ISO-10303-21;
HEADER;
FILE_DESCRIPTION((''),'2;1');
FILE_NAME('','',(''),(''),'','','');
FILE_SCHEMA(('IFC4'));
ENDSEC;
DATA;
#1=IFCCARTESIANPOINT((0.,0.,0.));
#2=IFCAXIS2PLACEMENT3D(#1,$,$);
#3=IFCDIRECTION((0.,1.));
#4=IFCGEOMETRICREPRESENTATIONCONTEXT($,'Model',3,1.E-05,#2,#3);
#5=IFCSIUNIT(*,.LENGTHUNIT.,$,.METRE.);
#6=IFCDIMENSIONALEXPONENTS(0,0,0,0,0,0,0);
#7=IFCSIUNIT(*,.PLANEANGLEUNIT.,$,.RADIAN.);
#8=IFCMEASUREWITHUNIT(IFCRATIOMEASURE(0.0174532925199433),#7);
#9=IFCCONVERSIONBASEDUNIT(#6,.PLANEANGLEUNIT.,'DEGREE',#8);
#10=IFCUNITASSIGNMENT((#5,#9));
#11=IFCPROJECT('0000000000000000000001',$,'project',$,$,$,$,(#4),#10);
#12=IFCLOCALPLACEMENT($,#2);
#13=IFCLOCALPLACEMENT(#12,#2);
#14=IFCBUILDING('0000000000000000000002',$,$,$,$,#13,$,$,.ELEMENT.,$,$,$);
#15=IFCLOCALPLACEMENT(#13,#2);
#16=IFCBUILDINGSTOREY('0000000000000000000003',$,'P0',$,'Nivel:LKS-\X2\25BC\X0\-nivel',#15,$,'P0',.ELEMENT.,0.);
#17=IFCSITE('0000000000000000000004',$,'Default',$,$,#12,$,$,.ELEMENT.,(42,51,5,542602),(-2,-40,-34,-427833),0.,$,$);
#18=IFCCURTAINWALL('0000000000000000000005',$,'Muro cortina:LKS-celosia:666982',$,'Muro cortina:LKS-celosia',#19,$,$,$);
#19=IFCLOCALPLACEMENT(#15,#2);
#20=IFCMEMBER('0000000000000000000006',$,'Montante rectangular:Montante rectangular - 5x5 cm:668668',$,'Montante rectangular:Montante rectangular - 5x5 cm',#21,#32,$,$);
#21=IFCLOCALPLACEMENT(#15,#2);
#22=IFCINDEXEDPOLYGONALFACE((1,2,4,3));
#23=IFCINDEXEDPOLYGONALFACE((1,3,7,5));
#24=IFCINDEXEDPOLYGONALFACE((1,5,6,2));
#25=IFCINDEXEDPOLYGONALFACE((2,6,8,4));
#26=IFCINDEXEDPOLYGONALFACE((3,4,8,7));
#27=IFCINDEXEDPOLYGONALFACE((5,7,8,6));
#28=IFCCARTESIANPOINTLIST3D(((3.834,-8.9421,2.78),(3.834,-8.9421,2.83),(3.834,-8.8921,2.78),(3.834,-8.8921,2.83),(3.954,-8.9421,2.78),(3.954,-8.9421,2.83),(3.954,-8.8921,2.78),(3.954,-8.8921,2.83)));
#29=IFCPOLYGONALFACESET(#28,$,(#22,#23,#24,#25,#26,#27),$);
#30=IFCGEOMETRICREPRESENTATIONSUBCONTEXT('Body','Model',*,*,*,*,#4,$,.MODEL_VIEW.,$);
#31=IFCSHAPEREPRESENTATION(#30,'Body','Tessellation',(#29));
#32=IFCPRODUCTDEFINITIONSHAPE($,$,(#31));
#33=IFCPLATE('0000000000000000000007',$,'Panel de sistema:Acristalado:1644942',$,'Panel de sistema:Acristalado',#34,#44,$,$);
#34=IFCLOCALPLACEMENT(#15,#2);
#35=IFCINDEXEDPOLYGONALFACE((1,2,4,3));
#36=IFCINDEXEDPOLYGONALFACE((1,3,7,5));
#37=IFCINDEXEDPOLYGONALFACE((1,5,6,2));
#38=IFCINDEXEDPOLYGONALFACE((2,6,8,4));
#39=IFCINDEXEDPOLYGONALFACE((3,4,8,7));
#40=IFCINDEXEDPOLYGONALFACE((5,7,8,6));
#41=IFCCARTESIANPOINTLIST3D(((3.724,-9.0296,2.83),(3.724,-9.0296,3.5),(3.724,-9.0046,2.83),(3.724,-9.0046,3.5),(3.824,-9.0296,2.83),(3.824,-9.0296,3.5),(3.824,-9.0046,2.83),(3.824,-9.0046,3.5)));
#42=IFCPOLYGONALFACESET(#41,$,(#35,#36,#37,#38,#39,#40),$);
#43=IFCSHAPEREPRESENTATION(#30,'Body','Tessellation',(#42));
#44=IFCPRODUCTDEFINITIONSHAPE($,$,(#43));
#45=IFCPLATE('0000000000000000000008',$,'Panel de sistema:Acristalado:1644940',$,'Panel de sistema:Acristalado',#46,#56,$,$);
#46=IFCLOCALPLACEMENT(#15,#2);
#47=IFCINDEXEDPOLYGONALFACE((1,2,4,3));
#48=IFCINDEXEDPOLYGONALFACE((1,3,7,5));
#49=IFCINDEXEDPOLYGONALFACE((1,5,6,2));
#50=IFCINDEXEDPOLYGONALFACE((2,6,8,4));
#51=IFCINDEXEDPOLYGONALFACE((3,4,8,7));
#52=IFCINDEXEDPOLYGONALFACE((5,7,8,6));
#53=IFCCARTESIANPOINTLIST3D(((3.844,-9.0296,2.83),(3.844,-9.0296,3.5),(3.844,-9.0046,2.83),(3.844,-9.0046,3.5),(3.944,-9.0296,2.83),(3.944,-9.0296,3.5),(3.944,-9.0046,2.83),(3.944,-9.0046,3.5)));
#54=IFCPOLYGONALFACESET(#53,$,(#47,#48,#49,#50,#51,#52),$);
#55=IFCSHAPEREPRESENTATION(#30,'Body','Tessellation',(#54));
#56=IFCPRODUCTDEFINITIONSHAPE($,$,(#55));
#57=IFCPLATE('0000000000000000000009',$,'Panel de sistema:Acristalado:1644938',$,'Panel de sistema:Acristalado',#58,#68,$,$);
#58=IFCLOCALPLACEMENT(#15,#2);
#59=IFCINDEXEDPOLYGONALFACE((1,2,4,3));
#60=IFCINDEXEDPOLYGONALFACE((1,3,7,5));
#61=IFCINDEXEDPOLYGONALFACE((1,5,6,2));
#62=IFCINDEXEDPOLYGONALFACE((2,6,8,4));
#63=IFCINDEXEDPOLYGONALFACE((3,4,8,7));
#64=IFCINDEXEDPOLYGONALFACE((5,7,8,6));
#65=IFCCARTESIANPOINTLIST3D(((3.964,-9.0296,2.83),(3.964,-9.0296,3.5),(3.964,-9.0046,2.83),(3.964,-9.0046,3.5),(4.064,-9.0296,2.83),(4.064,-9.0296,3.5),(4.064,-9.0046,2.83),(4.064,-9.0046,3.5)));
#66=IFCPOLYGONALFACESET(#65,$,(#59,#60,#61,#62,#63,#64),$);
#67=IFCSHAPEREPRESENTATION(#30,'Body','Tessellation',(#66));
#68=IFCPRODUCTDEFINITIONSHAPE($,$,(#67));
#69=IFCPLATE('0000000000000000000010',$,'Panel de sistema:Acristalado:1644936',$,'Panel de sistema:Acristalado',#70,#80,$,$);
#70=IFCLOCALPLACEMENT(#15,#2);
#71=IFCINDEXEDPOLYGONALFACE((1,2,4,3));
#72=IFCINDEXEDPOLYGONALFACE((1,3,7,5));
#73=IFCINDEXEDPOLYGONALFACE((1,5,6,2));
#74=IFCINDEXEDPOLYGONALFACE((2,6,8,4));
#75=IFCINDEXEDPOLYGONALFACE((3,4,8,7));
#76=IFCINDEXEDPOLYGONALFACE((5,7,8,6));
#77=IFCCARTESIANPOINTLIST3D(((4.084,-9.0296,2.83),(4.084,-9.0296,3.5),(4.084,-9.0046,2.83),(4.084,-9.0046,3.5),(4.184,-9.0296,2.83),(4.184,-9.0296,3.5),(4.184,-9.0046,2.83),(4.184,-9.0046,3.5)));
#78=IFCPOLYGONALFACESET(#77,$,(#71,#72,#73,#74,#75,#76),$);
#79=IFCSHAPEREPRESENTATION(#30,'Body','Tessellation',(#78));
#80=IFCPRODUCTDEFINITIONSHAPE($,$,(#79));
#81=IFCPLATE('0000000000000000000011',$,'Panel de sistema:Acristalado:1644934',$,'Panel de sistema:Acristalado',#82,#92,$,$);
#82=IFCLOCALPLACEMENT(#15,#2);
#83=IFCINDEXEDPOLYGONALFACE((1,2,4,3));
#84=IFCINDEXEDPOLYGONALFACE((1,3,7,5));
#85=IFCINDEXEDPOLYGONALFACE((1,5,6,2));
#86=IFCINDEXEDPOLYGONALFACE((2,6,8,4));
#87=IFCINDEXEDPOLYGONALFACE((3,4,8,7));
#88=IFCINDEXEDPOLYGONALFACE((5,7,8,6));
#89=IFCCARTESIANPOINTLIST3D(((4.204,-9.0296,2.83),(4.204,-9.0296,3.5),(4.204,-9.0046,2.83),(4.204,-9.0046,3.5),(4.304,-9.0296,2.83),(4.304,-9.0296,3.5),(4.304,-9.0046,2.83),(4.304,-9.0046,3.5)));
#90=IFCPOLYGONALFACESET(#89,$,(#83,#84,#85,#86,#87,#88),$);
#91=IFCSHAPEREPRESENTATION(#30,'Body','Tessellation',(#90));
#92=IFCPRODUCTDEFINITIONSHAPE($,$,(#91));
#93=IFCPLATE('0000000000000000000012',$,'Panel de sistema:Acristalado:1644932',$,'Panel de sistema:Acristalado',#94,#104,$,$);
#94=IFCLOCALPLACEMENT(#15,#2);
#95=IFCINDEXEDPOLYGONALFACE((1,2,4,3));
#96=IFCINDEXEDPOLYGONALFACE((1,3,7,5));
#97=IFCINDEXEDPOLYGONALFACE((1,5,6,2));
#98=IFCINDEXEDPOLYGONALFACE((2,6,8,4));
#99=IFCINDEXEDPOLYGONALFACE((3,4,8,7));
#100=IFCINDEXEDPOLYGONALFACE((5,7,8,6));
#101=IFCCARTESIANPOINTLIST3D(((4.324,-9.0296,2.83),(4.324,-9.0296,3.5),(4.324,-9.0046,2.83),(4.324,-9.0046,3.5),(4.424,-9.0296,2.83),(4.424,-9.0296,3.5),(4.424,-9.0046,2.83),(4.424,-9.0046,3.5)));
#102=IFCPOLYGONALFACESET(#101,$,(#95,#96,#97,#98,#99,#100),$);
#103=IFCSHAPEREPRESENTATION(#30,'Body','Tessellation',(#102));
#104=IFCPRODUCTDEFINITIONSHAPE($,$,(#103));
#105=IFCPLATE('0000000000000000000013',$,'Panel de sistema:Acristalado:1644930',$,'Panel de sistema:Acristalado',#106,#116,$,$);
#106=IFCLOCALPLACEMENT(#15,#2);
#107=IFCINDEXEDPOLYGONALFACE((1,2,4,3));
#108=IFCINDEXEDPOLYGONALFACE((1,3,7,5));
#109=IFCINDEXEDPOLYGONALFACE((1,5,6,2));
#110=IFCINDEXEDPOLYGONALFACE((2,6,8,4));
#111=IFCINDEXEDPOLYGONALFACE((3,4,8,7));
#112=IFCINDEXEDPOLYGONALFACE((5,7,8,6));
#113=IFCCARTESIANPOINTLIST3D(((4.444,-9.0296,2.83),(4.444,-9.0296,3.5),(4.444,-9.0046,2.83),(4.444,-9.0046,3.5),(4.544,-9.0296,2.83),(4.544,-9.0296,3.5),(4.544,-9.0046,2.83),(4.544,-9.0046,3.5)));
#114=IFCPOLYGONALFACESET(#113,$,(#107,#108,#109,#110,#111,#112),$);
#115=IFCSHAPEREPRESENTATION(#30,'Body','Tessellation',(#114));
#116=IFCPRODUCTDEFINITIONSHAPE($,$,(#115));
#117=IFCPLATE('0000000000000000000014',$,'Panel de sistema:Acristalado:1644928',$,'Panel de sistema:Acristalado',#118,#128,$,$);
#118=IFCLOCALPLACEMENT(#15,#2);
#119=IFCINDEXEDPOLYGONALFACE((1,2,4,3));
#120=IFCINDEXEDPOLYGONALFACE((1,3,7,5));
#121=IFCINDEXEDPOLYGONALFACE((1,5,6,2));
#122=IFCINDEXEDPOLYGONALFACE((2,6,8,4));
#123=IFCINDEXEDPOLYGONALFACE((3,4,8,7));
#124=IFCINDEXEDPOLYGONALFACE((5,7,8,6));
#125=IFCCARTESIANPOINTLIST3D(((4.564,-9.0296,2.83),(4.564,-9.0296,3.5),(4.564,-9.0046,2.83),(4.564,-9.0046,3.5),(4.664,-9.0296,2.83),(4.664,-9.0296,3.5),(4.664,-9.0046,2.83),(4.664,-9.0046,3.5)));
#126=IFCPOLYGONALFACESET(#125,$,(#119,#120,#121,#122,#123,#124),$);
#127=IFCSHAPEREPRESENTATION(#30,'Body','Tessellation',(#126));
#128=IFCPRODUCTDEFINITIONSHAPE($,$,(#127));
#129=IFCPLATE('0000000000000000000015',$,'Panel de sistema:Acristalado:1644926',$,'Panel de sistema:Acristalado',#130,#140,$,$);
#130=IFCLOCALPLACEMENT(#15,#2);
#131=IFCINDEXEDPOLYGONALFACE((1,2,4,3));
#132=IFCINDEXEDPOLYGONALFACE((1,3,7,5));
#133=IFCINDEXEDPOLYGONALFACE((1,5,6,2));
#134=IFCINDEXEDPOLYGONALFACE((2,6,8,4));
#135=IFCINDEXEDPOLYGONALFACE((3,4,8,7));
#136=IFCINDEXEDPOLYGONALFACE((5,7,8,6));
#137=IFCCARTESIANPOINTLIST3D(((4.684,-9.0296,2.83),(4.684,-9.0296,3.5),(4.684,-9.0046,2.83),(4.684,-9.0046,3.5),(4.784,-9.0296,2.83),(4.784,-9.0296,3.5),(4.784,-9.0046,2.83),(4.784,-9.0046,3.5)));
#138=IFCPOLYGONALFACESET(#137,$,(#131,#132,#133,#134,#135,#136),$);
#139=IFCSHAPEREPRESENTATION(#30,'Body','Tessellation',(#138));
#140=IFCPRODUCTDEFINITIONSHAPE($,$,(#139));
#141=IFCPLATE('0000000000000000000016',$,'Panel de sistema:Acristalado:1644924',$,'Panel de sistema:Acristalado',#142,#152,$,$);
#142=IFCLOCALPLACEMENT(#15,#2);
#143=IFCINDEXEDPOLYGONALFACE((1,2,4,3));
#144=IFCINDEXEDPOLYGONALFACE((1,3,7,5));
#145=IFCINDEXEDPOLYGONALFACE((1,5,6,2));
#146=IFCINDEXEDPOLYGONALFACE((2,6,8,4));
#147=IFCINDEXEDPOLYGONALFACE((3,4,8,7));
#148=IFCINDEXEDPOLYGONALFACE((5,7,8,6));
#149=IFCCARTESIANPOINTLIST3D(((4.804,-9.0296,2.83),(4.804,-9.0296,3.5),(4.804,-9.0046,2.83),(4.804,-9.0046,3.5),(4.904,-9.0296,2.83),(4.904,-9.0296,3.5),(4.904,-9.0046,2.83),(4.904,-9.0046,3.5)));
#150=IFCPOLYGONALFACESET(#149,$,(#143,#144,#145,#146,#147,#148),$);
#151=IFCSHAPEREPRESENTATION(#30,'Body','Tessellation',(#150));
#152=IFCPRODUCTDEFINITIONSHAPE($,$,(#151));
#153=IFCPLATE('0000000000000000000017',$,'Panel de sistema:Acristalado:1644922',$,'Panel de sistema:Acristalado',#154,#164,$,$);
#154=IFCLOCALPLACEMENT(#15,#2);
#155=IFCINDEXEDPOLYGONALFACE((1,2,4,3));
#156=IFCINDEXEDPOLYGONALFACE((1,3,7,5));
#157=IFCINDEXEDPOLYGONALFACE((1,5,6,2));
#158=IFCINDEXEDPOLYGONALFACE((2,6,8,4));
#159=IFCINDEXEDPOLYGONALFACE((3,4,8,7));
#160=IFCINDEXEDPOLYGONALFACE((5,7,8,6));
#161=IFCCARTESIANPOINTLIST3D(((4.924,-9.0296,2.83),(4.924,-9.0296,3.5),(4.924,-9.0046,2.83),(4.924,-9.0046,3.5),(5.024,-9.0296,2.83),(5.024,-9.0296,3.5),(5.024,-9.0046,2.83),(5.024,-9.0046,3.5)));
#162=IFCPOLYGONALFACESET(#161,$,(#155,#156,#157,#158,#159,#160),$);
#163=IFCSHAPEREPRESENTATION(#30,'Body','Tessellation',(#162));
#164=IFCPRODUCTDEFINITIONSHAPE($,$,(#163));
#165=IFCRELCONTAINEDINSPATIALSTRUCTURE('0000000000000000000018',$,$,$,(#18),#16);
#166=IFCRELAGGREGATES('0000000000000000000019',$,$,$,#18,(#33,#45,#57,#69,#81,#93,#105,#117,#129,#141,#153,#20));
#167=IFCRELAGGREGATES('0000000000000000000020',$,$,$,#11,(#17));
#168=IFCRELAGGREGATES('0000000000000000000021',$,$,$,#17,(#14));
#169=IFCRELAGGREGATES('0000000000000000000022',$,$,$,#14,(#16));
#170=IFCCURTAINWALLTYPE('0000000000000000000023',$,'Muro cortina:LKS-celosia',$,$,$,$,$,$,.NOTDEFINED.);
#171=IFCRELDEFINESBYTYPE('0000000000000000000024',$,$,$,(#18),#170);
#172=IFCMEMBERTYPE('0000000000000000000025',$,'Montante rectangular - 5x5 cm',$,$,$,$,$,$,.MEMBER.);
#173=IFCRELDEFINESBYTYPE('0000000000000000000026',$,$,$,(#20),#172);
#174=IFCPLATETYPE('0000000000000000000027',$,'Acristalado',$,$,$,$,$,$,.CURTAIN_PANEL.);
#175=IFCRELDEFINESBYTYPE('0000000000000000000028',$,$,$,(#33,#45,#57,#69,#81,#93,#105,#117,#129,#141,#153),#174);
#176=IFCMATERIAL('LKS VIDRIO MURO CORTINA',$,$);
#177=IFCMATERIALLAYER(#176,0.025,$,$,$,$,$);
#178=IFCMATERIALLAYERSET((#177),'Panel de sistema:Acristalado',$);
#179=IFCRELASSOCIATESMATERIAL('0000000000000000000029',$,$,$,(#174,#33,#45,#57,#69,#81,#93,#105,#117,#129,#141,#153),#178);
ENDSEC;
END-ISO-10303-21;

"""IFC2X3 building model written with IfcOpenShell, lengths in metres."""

from ifc_helpers import new_model, entity, si_unit, converted_unit, direction, frame, origin, origin_2d_with_axis, place, context, subcontext, project, spatial, rectangle, extrude, source, transform, mapped, material, layer, layer_set, layer_usage, type_object, type_shapes, element, aggregate, save


model = new_model("IFC2X3")

# Units and contexts
model_context = context("Model", 3, precision=1e-05, world=origin(), true_north=direction((0.0, 1.0)))
body_context = subcontext(model_context, "Body", "Model", "MODEL_VIEW")
ifc_project = project(units=[si_unit("LENGTHUNIT", "METRE"), converted_unit("PLANEANGLEUNIT", "DEGREE", entity("IfcRatioMeasure", 0.0174532925199433), si_unit("PLANEANGLEUNIT", "RADIAN"), dimensions=[0, 0, 0, 0, 0, 0, 0])], contexts=[model_context])

# Site, building, storey
site_placement = place(None, origin())
site = spatial("IfcSite", under=ifc_project, at=site_placement, Name="Default", CompositionType="ELEMENT", RefLatitude=(42, 51, 5, 542602), RefLongitude=(-2, -40, -34, -427833), RefElevation=0.0)
building_placement = place(site_placement, origin())
building = spatial("IfcBuilding", under=site, at=building_placement, CompositionType="ELEMENT")
storey_placement = place(building_placement, origin())
storey = spatial("IfcBuildingStorey", under=building, at=storey_placement, Name="P0", ObjectType="Nivel:LKS-▼-nivel", LongName="P0", CompositionType="ELEMENT", Elevation=0.0)

# Curtain wall, member, plates
curtain_wall_type = type_object("IfcCurtainWallType", Name="Muro cortina:LKS-celosia", PredefinedType="NOTDEFINED")
curtain_wall_placement = place(storey_placement, origin())
curtain_wall = element("IfcCurtainWall", 1, at=curtain_wall_placement, inside=storey, type_object=curtain_wall_type, Name="Muro cortina:LKS-celosia:666982", ObjectType="Muro cortina:LKS-celosia")
member_type_1 = type_object("IfcMemberType", Name="Montante rectangular - 5x5 cm", PredefinedType="MEMBER")
shared_shape_1 = source(origin(), body_context, "Body", "SweptSolid", [
    extrude(rectangle(XDim=0.05, YDim=0.05, at=origin_2d_with_axis()), frame((-0.025, -0.1, -0.12), z_axis=(0.0, 0.0, 1.0), x_axis=(0.0, -1.0, 0.0)), (0.0, 0.0, 1.0), 0.12),
])
type_shapes(member_type_1, [shared_shape_1])
member_1_placement = place(storey_placement, frame((3.834, -9.0171, 2.78), z_axis=(-1.0, 0.0, 0.0), x_axis=(0.0, 0.0, -1.0)))
member_1 = element("IfcMember", 2, at=member_1_placement, type_object=member_type_1, Name="Montante rectangular:Montante rectangular - 5x5 cm:668668", ObjectType="Montante rectangular:Montante rectangular - 5x5 cm", context=body_context, shape_type="MappedRepresentation", body=[
    mapped(shared_shape_1, transform((0.0, 0.0, 0.0), scale=1.0)),
])
ifc_material = material(Name="LKS VIDRIO MURO CORTINA")
ifc_layer = layer(ifc_material, 0.025)
ifc_layer_set = layer_set([ifc_layer], Name="Panel de sistema:Acristalado")
ifc_layer_usage_1 = layer_usage(ifc_layer_set, "AXIS3", "POSITIVE", 0.0)
plate_type = type_object("IfcPlateType", Name="Acristalado", PredefinedType="CURTAIN_PANEL", material=ifc_layer_set)
shared_shape_2 = source(origin(), body_context, "Body", "SweptSolid", [
    extrude(rectangle(XDim=0.025, YDim=0.1, at=origin_2d_with_axis()), frame((0.0, 0.0, 0.0), z_axis=(0.0, 0.0, 1.0), x_axis=(0.0, 1.0, 0.0)), (0.0, 0.0, 1.0), 0.67),
])
type_shapes(plate_type, [shared_shape_2])
plate_1_placement = place(curtain_wall_placement, frame((3.774, -9.0171, 2.83)))
plate_1 = element("IfcPlate", 3, at=plate_1_placement, type_object=plate_type, material=ifc_layer_usage_1, Name="Panel de sistema:Acristalado:1644942", ObjectType="Panel de sistema:Acristalado", context=body_context, shape_type="MappedRepresentation", body=[
    mapped(shared_shape_2, transform((0.0, 0.0, 0.0), scale=1.0)),
])
ifc_layer_usage_2 = layer_usage(ifc_layer_set, "AXIS3", "POSITIVE", 0.0)
plate_2_placement = place(curtain_wall_placement, frame((3.894, -9.0171, 2.83)))
plate_2 = element("IfcPlate", 4, at=plate_2_placement, type_object=plate_type, material=ifc_layer_usage_2, Name="Panel de sistema:Acristalado:1644940", ObjectType="Panel de sistema:Acristalado", context=body_context, shape_type="MappedRepresentation", body=[
    mapped(shared_shape_2, transform((0.0, 0.0, 0.0), scale=1.0)),
])
ifc_layer_usage_3 = layer_usage(ifc_layer_set, "AXIS3", "POSITIVE", 0.0)
plate_3_placement = place(curtain_wall_placement, frame((4.014, -9.0171, 2.83)))
plate_3 = element("IfcPlate", 5, at=plate_3_placement, type_object=plate_type, material=ifc_layer_usage_3, Name="Panel de sistema:Acristalado:1644938", ObjectType="Panel de sistema:Acristalado", context=body_context, shape_type="MappedRepresentation", body=[
    mapped(shared_shape_2, transform((0.0, 0.0, 0.0), scale=1.0)),
])
ifc_layer_usage_4 = layer_usage(ifc_layer_set, "AXIS3", "POSITIVE", 0.0)
plate_4_placement = place(curtain_wall_placement, frame((4.134, -9.0171, 2.83)))
plate_4 = element("IfcPlate", 6, at=plate_4_placement, type_object=plate_type, material=ifc_layer_usage_4, Name="Panel de sistema:Acristalado:1644936", ObjectType="Panel de sistema:Acristalado", context=body_context, shape_type="MappedRepresentation", body=[
    mapped(shared_shape_2, transform((0.0, 0.0, 0.0), scale=1.0)),
])
ifc_layer_usage_5 = layer_usage(ifc_layer_set, "AXIS3", "POSITIVE", 0.0)
plate_5_placement = place(curtain_wall_placement, frame((4.254, -9.0171, 2.83)))
plate_5 = element("IfcPlate", 7, at=plate_5_placement, type_object=plate_type, material=ifc_layer_usage_5, Name="Panel de sistema:Acristalado:1644934", ObjectType="Panel de sistema:Acristalado", context=body_context, shape_type="MappedRepresentation", body=[
    mapped(shared_shape_2, transform((0.0, 0.0, 0.0), scale=1.0)),
])
ifc_layer_usage_6 = layer_usage(ifc_layer_set, "AXIS3", "POSITIVE", 0.0)
plate_6_placement = place(curtain_wall_placement, frame((4.374, -9.0171, 2.83)))
plate_6 = element("IfcPlate", 8, at=plate_6_placement, type_object=plate_type, material=ifc_layer_usage_6, Name="Panel de sistema:Acristalado:1644932", ObjectType="Panel de sistema:Acristalado", context=body_context, shape_type="MappedRepresentation", body=[
    mapped(shared_shape_2, transform((0.0, 0.0, 0.0), scale=1.0)),
])
ifc_layer_usage_7 = layer_usage(ifc_layer_set, "AXIS3", "POSITIVE", 0.0)
plate_7_placement = place(curtain_wall_placement, frame((4.494, -9.0171, 2.83)))
plate_7 = element("IfcPlate", 9, at=plate_7_placement, type_object=plate_type, material=ifc_layer_usage_7, Name="Panel de sistema:Acristalado:1644930", ObjectType="Panel de sistema:Acristalado", context=body_context, shape_type="MappedRepresentation", body=[
    mapped(shared_shape_2, transform((0.0, 0.0, 0.0), scale=1.0)),
])
ifc_layer_usage_8 = layer_usage(ifc_layer_set, "AXIS3", "POSITIVE", 0.0)
plate_8_placement = place(curtain_wall_placement, frame((4.614, -9.0171, 2.83)))
plate_8 = element("IfcPlate", 10, at=plate_8_placement, type_object=plate_type, material=ifc_layer_usage_8, Name="Panel de sistema:Acristalado:1644928", ObjectType="Panel de sistema:Acristalado", context=body_context, shape_type="MappedRepresentation", body=[
    mapped(shared_shape_2, transform((0.0, 0.0, 0.0), scale=1.0)),
])
ifc_layer_usage_9 = layer_usage(ifc_layer_set, "AXIS3", "POSITIVE", 0.0)
plate_9_placement = place(curtain_wall_placement, frame((4.734, -9.0171, 2.83)))
plate_9 = element("IfcPlate", 11, at=plate_9_placement, type_object=plate_type, material=ifc_layer_usage_9, Name="Panel de sistema:Acristalado:1644926", ObjectType="Panel de sistema:Acristalado", context=body_context, shape_type="MappedRepresentation", body=[
    mapped(shared_shape_2, transform((0.0, 0.0, 0.0), scale=1.0)),
])
ifc_layer_usage_10 = layer_usage(ifc_layer_set, "AXIS3", "POSITIVE", 0.0)
plate_10_placement = place(curtain_wall_placement, frame((4.854, -9.0171, 2.83)))
plate_10 = element("IfcPlate", 12, at=plate_10_placement, type_object=plate_type, material=ifc_layer_usage_10, Name="Panel de sistema:Acristalado:1644924", ObjectType="Panel de sistema:Acristalado", context=body_context, shape_type="MappedRepresentation", body=[
    mapped(shared_shape_2, transform((0.0, 0.0, 0.0), scale=1.0)),
])
ifc_layer_usage_11 = layer_usage(ifc_layer_set, "AXIS3", "POSITIVE", 0.0)
plate_11_placement = place(curtain_wall_placement, frame((4.974, -9.0171, 2.83)))
plate_11 = element("IfcPlate", 13, at=plate_11_placement, type_object=plate_type, material=ifc_layer_usage_11, Name="Panel de sistema:Acristalado:1644922", ObjectType="Panel de sistema:Acristalado", context=body_context, shape_type="MappedRepresentation", body=[
    mapped(shared_shape_2, transform((0.0, 0.0, 0.0), scale=1.0)),
])
aggregate(curtain_wall, [plate_1, plate_2, plate_3, plate_4, plate_5, plate_6, plate_7, plate_8, plate_9, plate_10, plate_11, member_1])

save(model, "model.ifc")
